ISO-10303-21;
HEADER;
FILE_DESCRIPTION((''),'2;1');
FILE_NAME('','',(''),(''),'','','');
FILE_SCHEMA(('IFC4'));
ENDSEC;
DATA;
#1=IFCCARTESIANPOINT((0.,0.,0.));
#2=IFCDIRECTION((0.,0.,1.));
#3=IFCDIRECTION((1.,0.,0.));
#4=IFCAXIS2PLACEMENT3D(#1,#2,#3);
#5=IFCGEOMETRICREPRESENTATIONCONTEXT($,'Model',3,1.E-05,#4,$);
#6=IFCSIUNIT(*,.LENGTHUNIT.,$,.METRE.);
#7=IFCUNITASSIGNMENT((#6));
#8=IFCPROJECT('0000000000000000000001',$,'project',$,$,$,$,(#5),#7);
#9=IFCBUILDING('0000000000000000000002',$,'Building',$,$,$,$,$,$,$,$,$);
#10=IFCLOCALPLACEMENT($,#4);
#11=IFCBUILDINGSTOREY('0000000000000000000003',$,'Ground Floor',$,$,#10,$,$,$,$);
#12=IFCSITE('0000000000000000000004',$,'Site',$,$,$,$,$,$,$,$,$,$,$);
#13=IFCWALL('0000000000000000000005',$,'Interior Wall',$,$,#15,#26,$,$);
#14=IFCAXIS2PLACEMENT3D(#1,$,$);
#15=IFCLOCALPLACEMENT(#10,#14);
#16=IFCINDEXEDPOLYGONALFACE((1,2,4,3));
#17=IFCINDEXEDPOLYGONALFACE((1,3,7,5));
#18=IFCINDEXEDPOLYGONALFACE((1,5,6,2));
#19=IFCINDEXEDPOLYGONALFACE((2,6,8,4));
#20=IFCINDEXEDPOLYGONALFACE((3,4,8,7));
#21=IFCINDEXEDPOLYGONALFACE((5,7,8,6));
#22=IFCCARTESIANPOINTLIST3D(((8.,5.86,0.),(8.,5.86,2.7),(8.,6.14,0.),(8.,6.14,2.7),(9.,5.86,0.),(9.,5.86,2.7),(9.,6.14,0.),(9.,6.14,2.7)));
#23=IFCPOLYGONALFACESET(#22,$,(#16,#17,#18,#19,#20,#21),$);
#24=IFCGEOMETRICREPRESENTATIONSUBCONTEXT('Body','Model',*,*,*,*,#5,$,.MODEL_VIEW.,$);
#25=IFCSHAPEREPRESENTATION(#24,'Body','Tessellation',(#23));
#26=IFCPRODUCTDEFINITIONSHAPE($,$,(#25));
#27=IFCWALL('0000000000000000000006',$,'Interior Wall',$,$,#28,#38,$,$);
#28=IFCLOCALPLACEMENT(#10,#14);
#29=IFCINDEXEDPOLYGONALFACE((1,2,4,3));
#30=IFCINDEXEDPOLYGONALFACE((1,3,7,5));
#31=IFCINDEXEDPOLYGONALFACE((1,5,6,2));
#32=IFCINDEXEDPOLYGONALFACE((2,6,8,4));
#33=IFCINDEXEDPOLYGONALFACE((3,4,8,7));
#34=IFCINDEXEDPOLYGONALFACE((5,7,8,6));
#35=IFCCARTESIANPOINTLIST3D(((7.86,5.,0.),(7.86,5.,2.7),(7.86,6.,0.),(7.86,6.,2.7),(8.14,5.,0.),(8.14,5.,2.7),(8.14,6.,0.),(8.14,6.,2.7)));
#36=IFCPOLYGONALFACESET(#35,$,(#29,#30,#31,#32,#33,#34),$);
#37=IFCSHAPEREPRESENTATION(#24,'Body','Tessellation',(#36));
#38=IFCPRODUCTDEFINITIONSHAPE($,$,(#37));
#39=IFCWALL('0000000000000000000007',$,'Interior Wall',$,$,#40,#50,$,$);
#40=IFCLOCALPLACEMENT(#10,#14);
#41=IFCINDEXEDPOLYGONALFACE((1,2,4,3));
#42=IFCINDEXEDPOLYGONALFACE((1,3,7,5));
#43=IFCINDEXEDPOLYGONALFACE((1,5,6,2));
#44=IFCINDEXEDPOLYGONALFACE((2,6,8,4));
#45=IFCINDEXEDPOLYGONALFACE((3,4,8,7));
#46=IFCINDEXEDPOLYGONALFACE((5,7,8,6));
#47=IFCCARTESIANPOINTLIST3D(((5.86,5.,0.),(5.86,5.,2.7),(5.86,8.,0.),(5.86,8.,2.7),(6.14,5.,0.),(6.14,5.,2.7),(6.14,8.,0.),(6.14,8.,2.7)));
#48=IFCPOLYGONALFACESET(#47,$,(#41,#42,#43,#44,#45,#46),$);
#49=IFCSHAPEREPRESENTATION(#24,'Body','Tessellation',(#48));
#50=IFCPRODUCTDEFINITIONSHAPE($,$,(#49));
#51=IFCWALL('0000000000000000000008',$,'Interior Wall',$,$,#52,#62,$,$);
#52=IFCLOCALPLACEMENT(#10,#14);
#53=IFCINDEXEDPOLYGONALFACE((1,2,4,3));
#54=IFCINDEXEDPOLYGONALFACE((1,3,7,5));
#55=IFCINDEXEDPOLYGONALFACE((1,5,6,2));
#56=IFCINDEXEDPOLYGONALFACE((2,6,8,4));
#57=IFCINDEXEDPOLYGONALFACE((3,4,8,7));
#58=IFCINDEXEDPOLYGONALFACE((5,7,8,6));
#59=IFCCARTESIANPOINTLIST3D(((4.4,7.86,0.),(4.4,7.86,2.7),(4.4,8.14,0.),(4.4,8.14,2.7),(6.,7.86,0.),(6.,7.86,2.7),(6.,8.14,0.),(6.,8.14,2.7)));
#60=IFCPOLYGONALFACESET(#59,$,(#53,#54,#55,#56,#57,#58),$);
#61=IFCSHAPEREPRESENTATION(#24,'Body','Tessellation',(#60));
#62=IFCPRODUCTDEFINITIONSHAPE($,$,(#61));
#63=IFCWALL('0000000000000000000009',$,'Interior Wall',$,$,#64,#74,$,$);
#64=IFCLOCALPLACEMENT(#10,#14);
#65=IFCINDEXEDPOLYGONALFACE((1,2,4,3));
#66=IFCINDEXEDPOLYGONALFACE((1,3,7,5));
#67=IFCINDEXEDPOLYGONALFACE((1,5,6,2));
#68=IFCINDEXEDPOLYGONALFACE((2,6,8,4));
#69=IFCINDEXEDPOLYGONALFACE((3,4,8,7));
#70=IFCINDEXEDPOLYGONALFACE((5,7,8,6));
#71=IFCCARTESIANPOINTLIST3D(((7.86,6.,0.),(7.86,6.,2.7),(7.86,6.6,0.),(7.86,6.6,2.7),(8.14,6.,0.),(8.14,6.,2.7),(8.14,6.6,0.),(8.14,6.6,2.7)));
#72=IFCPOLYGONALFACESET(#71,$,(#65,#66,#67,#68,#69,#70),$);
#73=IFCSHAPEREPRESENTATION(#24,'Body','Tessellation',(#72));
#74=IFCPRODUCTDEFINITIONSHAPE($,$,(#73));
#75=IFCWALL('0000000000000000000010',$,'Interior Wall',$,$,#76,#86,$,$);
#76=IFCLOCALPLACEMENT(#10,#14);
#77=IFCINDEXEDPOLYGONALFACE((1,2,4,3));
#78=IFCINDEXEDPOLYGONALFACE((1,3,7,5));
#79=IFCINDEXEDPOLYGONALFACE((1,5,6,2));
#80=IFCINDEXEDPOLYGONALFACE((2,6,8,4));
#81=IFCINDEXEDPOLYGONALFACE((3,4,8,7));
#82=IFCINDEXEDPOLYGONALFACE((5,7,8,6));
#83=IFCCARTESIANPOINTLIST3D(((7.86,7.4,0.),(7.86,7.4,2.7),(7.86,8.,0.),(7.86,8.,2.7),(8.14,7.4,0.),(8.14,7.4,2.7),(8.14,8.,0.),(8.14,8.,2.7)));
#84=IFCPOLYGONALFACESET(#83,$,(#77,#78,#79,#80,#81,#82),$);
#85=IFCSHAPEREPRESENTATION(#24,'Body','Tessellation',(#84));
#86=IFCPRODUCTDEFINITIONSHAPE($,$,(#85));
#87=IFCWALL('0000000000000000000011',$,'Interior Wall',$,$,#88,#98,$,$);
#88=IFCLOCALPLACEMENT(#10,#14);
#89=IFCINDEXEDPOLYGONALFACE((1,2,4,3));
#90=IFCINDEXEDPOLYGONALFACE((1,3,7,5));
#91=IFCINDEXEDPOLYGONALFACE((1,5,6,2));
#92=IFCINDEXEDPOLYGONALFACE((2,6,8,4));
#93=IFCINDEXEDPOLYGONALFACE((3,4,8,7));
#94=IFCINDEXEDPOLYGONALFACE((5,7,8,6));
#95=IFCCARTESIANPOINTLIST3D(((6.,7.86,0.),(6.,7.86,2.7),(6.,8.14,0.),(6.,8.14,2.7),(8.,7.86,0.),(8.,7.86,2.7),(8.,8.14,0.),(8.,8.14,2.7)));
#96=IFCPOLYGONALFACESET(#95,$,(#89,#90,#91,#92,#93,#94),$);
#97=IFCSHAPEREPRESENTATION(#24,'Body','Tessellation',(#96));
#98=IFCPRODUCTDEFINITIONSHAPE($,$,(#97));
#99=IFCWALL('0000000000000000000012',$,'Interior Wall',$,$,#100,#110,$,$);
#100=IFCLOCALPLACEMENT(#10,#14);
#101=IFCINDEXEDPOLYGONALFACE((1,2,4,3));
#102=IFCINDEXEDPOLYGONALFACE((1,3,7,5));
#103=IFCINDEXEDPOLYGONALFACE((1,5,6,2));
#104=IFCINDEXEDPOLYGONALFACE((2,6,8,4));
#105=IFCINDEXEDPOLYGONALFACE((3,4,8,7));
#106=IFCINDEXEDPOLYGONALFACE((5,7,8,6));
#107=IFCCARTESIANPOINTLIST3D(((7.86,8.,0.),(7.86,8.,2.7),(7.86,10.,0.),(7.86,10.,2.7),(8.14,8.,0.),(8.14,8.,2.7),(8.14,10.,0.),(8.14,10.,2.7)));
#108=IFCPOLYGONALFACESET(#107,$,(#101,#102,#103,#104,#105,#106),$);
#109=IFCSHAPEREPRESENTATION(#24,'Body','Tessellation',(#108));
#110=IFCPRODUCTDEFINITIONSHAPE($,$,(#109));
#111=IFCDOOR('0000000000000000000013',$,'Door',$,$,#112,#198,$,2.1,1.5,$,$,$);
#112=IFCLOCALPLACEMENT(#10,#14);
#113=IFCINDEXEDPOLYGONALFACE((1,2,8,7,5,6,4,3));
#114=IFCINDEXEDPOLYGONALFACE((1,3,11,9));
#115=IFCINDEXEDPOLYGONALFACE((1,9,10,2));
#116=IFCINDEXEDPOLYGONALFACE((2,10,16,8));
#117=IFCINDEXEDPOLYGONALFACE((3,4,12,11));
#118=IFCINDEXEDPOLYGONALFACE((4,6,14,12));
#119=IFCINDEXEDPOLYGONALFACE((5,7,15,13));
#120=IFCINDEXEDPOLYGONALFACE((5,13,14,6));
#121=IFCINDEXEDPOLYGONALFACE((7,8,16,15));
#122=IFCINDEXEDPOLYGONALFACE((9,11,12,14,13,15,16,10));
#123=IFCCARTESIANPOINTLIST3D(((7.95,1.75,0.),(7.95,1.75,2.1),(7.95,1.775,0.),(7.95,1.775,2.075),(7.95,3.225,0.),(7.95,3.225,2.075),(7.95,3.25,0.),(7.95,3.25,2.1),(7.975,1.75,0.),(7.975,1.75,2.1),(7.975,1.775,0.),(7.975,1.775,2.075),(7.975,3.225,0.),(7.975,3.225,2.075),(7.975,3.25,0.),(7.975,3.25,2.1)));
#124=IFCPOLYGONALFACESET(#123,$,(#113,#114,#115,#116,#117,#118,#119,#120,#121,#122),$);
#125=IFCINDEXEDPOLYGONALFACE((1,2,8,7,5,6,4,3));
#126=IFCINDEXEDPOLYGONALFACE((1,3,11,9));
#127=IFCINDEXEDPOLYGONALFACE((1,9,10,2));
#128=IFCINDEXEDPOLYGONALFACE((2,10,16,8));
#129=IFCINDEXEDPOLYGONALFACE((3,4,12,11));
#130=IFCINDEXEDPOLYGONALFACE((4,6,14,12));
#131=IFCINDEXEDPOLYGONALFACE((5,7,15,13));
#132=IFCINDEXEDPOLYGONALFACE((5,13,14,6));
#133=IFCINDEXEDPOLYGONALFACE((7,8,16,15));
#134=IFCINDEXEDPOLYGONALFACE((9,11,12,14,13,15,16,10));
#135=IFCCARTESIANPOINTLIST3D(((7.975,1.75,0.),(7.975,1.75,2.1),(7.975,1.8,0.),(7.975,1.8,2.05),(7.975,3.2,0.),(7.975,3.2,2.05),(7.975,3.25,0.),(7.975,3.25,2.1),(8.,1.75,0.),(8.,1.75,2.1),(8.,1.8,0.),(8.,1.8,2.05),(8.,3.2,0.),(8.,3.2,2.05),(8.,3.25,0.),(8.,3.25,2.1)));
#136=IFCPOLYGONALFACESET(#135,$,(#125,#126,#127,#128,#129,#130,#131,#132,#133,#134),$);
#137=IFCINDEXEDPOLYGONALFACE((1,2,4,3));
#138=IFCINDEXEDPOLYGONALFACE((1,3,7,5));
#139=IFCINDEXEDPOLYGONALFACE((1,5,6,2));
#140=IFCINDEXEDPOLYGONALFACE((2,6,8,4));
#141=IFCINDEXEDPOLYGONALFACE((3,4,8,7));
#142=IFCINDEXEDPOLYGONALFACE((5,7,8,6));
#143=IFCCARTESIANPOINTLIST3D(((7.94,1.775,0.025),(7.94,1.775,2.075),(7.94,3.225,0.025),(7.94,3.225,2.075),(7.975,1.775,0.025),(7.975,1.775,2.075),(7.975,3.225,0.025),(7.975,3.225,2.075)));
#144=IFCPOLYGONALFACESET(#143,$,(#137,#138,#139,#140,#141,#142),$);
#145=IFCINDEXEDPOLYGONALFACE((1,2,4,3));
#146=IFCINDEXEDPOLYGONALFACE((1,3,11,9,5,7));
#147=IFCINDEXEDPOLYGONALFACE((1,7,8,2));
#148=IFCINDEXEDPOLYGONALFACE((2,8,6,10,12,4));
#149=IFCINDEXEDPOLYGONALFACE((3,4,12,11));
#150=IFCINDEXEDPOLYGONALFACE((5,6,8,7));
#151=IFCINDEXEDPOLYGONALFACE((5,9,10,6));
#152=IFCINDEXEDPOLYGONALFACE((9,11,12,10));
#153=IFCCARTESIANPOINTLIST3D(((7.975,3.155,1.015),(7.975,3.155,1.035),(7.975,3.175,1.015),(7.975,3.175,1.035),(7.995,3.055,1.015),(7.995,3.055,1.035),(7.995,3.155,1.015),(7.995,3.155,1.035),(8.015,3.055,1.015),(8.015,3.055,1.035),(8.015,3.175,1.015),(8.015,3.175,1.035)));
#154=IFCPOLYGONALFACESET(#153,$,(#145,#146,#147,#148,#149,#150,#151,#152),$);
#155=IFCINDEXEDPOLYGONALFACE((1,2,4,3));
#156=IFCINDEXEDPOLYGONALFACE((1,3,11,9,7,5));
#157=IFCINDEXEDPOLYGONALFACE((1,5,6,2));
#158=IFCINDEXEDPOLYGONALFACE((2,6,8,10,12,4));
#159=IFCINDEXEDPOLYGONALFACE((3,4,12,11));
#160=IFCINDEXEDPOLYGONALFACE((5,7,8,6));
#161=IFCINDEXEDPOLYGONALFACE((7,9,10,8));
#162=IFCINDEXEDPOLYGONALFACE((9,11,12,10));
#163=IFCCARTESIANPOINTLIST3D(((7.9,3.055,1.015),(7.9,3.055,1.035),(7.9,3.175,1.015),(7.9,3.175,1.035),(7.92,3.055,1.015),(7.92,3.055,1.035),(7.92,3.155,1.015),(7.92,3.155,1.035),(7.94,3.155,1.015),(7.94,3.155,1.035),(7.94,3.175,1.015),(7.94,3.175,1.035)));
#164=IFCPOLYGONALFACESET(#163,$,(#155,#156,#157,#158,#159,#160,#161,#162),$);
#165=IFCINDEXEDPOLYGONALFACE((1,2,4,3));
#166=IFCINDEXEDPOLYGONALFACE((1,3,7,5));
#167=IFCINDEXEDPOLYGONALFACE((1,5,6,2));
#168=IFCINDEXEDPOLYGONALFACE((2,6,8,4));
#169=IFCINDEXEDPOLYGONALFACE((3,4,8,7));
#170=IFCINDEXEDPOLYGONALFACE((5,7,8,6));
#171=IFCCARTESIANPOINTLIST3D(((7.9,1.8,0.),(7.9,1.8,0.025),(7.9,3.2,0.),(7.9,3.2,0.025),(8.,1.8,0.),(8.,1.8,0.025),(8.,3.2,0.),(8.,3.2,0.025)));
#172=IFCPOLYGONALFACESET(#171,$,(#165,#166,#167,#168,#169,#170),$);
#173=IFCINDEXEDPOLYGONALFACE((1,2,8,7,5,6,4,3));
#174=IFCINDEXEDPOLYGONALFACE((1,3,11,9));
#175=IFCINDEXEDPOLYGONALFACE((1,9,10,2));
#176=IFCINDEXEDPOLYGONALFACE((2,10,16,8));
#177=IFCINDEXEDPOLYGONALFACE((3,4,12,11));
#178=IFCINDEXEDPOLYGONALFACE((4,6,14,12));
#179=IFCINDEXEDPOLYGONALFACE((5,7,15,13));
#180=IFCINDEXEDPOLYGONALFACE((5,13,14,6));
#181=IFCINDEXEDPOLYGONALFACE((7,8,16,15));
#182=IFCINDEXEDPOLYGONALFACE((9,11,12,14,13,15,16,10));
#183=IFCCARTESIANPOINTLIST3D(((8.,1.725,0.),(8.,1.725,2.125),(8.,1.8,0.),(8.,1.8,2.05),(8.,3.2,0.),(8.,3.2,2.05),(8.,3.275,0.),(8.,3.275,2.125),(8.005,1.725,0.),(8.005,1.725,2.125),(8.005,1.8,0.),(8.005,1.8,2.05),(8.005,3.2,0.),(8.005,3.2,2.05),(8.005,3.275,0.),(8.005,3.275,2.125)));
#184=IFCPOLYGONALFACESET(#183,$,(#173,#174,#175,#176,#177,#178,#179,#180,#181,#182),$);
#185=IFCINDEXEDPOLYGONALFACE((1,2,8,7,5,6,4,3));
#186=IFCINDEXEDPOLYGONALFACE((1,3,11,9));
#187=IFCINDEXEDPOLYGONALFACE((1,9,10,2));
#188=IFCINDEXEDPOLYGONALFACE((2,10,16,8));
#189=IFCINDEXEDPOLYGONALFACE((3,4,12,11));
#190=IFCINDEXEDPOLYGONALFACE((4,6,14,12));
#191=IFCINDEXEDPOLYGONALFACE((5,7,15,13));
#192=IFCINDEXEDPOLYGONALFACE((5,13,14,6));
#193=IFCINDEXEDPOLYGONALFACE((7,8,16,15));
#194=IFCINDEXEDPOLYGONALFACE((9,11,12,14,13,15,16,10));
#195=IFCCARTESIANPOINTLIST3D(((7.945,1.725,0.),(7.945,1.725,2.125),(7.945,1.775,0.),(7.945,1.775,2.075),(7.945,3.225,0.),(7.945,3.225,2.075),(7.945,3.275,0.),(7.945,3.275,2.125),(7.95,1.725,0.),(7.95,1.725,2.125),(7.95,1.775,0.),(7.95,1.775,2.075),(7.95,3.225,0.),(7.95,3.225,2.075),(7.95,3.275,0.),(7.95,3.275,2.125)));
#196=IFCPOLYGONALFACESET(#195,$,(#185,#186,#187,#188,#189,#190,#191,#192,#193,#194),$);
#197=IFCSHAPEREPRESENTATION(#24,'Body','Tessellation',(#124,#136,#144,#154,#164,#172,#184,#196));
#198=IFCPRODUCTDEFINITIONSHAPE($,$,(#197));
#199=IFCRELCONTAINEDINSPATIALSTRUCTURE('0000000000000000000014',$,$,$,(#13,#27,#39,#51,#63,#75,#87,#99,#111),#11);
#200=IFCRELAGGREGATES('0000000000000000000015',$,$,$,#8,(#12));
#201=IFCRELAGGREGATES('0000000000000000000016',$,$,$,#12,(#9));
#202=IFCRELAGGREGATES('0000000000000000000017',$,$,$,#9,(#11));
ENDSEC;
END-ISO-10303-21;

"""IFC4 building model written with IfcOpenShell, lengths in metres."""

from ifc_helpers import new_model, si_unit, frame, origin_with_axes, place, context, subcontext, project, spatial, line, indexed_curve, outline, extrude, element, save


model = new_model("IFC4")

# Units and contexts
model_context = context("Model", 3, precision=1e-05, world=origin_with_axes())
body_context = subcontext(model_context, "Body", "Model", "MODEL_VIEW")
ifc_project = project(units=[si_unit("LENGTHUNIT", "METRE")], contexts=[model_context])

# Site, building, storey
site = spatial("IfcSite", under=ifc_project, Name="Site")
building = spatial("IfcBuilding", under=site, Name="Building")
storey_placement = place(None, origin_with_axes())
storey = spatial("IfcBuildingStorey", under=building, at=storey_placement, Name="Ground Floor")

# Walls
for number, where, z_axis, x_axis, name in (
    (1, (9.0, 6.0, 0.0), (0.0, 0.0, 1.0), (-1.0, 0.0, 0.0), "Interior Wall"),
    (2, (8.0, 6.0, 0.0), (0.0, 0.0, 1.0), (0.0, -1.0, 0.0), "Interior Wall"),
):
    element("IfcWall", number, at=place(storey_placement, frame(where, z_axis=z_axis, x_axis=x_axis)), inside=storey, Name=name, context=body_context, shape_type="SweptSolid", body=[
        extrude(outline(indexed_curve([(0.0, 0.0), (0.0, 0.28), (1.0, 0.28), (1.0, 0.0), (0.0, 0.0)], self_intersect=False)), frame((0.0, -0.14, 0.0), z_axis=(0.0, 0.0, 1.0), x_axis=(1.0, 0.0, 0.0)), (0.0, 0.0, 1.0), 2.7),
    ])
wall_1_placement = place(storey_placement, frame((6.0, 5.0, 0.0), z_axis=(0.0, 0.0, 1.0), x_axis=(0.0, 1.0, 0.0)))
element("IfcWall", 3, at=wall_1_placement, inside=storey, Name="Interior Wall", context=body_context, shape_type="SweptSolid", body=[
    extrude(outline(indexed_curve([(0.0, 0.0), (0.0, 0.28), (3.0, 0.28), (3.0, 0.0), (0.0, 0.0)], self_intersect=False)), frame((0.0, -0.14, 0.0), z_axis=(0.0, 0.0, 1.0), x_axis=(1.0, 0.0, 0.0)), (0.0, 0.0, 1.0), 2.7),
])
wall_2_placement = place(storey_placement, frame((6.0, 8.0, 0.0), z_axis=(0.0, 0.0, 1.0), x_axis=(-1.0, 0.0, 0.0)))
element("IfcWall", 4, at=wall_2_placement, inside=storey, Name="Interior Wall", context=body_context, shape_type="SweptSolid", body=[
    extrude(outline(indexed_curve([(0.0, 0.0), (0.0, 0.28), (1.6, 0.28), (1.6, 0.0), (0.0, 0.0)], self_intersect=False)), frame((0.0, -0.14, 0.0), z_axis=(0.0, 0.0, 1.0), x_axis=(1.0, 0.0, 0.0)), (0.0, 0.0, 1.0), 2.7),
])
for number, where, z_axis, x_axis, name in (
    (5, (8.0, 6.0, 0.0), (0.0, 0.0, 1.0), (0.0, 1.0, 0.0), "Interior Wall"),
    (6, (8.0, 7.4, 0.0), (0.0, 0.0, 1.0), (0.0, 1.0, 0.0), "Interior Wall"),
):
    element("IfcWall", number, at=place(storey_placement, frame(where, z_axis=z_axis, x_axis=x_axis)), inside=storey, Name=name, context=body_context, shape_type="SweptSolid", body=[
        extrude(outline(indexed_curve([(0.0, 0.0), (0.0, 0.28), (0.6, 0.28), (0.6, 0.0), (0.0, 0.0)], self_intersect=False)), frame((0.0, -0.14, 0.0), z_axis=(0.0, 0.0, 1.0), x_axis=(1.0, 0.0, 0.0)), (0.0, 0.0, 1.0), 2.7),
    ])
for number, where, z_axis, x_axis, name in (
    (7, (8.0, 8.0, 0.0), (0.0, 0.0, 1.0), (-1.0, 0.0, 0.0), "Interior Wall"),
    (8, (8.0, 10.0, 0.0), (0.0, 0.0, 1.0), (0.0, -1.0, 0.0), "Interior Wall"),
):
    element("IfcWall", number, at=place(storey_placement, frame(where, z_axis=z_axis, x_axis=x_axis)), inside=storey, Name=name, context=body_context, shape_type="SweptSolid", body=[
        extrude(outline(indexed_curve([(0.0, 0.0), (0.0, 0.28), (2.0, 0.28), (2.0, 0.0), (0.0, 0.0)], self_intersect=False)), frame((0.0, -0.14, 0.0), z_axis=(0.0, 0.0, 1.0), x_axis=(1.0, 0.0, 0.0)), (0.0, 0.0, 1.0), 2.7),
    ])

# Door
door_1_placement = place(storey_placement, frame((8.0, 1.75, 0.0), z_axis=(0.0, 0.0, 1.0), x_axis=(0.0, 1.0, 0.0)))
element("IfcDoor", 9, at=door_1_placement, inside=storey, Name="Door", OverallHeight=2.1, OverallWidth=1.5, context=body_context, shape_type="SweptSolid", body=[
    extrude(outline(indexed_curve([(0.0, 0.0), (0.0, 2.1), (1.5, 2.1), (1.5, 0.0), (1.475, 0.0), (1.475, 2.075), (0.025, 2.075), (0.025, 0.0)], segments=[line(1, 2, 3, 4, 5, 6, 7, 8, 1)])), frame((0.0, 0.025, 0.0), z_axis=(0.0, -1.0, 0.0), x_axis=(1.0, 0.0, 0.0)), (0.0, 0.0, -1.0), 0.025),
    extrude(outline(indexed_curve([(0.0, 0.0), (0.0, 2.1), (1.5, 2.1), (1.5, 0.0), (1.45, 0.0), (1.45, 2.05), (0.05, 2.05), (0.05, 0.0)], segments=[line(1, 2, 3, 4, 5, 6, 7, 8, 1)])), frame((0.0, 0.0, 0.0), z_axis=(0.0, -1.0, 0.0), x_axis=(1.0, 0.0, 0.0)), (0.0, 0.0, -1.0), 0.025),
    extrude(outline(indexed_curve([(0.0, 0.0), (1.45, 0.0), (1.45, 0.035), (0.0, 0.035)], segments=[line(1, 2, 3, 4, 1)])), frame((0.025, 0.025, 0.025), z_axis=(0.0, 0.0, 1.0), x_axis=(1.0, 0.0, 0.0)), (0.0, 0.0, 1.0), 2.05),
    extrude(outline(indexed_curve([(0.0, 0.0), (0.0, -0.04), (-0.12, -0.04), (-0.12, -0.02), (-0.02, -0.02), (-0.02, 0.0)], segments=[line(1, 2, 3, 4, 5, 6, 1)])), frame((1.425, 0.025, 1.015), z_axis=(0.0, 0.0, 1.0), x_axis=(1.0, 0.0, 0.0)), (0.0, 0.0, 1.0), 0.02),
    extrude(outline(indexed_curve([(0.0, 0.0), (0.0, 0.04), (-0.12, 0.04), (-0.12, 0.02), (-0.02, 0.02), (-0.02, 0.0)], segments=[line(1, 2, 3, 4, 5, 6, 1)])), frame((1.425, 0.06, 1.015), z_axis=(0.0, 0.0, 1.0), x_axis=(1.0, 0.0, 0.0)), (0.0, 0.0, 1.0), 0.02),
    extrude(outline(indexed_curve([(0.0, 0.0), (1.4, 0.0), (1.4, 0.1), (0.0, 0.1)], segments=[line(1, 2, 3, 4, 1)])), frame((0.05, 0.0, 0.0), z_axis=(0.0, 0.0, 1.0), x_axis=(1.0, 0.0, 0.0)), (0.0, 0.0, 1.0), 0.025),
    extrude(outline(indexed_curve([(0.0, 0.0), (0.0, 2.125), (1.55, 2.125), (1.55, 0.0), (1.475, 0.0), (1.475, 2.05), (0.075, 2.05), (0.075, 0.0)], segments=[line(1, 2, 3, 4, 5, 6, 7, 8, 1)])), frame((-0.025, -0.005, 0.0), z_axis=(0.0, -1.0, 0.0), x_axis=(1.0, 0.0, 0.0)), (0.0, 0.0, -1.0), 0.005),
    extrude(outline(indexed_curve([(0.0, 0.0), (0.0, 2.125), (1.55, 2.125), (1.55, 0.0), (1.5, 0.0), (1.5, 2.075), (0.05, 2.075), (0.05, 0.0)], segments=[line(1, 2, 3, 4, 5, 6, 7, 8, 1)])), frame((-0.025, 0.05, 0.0), z_axis=(0.0, -1.0, 0.0), x_axis=(1.0, 0.0, 0.0)), (0.0, 0.0, -1.0), 0.005),
])

save(model, "model.ifc")
